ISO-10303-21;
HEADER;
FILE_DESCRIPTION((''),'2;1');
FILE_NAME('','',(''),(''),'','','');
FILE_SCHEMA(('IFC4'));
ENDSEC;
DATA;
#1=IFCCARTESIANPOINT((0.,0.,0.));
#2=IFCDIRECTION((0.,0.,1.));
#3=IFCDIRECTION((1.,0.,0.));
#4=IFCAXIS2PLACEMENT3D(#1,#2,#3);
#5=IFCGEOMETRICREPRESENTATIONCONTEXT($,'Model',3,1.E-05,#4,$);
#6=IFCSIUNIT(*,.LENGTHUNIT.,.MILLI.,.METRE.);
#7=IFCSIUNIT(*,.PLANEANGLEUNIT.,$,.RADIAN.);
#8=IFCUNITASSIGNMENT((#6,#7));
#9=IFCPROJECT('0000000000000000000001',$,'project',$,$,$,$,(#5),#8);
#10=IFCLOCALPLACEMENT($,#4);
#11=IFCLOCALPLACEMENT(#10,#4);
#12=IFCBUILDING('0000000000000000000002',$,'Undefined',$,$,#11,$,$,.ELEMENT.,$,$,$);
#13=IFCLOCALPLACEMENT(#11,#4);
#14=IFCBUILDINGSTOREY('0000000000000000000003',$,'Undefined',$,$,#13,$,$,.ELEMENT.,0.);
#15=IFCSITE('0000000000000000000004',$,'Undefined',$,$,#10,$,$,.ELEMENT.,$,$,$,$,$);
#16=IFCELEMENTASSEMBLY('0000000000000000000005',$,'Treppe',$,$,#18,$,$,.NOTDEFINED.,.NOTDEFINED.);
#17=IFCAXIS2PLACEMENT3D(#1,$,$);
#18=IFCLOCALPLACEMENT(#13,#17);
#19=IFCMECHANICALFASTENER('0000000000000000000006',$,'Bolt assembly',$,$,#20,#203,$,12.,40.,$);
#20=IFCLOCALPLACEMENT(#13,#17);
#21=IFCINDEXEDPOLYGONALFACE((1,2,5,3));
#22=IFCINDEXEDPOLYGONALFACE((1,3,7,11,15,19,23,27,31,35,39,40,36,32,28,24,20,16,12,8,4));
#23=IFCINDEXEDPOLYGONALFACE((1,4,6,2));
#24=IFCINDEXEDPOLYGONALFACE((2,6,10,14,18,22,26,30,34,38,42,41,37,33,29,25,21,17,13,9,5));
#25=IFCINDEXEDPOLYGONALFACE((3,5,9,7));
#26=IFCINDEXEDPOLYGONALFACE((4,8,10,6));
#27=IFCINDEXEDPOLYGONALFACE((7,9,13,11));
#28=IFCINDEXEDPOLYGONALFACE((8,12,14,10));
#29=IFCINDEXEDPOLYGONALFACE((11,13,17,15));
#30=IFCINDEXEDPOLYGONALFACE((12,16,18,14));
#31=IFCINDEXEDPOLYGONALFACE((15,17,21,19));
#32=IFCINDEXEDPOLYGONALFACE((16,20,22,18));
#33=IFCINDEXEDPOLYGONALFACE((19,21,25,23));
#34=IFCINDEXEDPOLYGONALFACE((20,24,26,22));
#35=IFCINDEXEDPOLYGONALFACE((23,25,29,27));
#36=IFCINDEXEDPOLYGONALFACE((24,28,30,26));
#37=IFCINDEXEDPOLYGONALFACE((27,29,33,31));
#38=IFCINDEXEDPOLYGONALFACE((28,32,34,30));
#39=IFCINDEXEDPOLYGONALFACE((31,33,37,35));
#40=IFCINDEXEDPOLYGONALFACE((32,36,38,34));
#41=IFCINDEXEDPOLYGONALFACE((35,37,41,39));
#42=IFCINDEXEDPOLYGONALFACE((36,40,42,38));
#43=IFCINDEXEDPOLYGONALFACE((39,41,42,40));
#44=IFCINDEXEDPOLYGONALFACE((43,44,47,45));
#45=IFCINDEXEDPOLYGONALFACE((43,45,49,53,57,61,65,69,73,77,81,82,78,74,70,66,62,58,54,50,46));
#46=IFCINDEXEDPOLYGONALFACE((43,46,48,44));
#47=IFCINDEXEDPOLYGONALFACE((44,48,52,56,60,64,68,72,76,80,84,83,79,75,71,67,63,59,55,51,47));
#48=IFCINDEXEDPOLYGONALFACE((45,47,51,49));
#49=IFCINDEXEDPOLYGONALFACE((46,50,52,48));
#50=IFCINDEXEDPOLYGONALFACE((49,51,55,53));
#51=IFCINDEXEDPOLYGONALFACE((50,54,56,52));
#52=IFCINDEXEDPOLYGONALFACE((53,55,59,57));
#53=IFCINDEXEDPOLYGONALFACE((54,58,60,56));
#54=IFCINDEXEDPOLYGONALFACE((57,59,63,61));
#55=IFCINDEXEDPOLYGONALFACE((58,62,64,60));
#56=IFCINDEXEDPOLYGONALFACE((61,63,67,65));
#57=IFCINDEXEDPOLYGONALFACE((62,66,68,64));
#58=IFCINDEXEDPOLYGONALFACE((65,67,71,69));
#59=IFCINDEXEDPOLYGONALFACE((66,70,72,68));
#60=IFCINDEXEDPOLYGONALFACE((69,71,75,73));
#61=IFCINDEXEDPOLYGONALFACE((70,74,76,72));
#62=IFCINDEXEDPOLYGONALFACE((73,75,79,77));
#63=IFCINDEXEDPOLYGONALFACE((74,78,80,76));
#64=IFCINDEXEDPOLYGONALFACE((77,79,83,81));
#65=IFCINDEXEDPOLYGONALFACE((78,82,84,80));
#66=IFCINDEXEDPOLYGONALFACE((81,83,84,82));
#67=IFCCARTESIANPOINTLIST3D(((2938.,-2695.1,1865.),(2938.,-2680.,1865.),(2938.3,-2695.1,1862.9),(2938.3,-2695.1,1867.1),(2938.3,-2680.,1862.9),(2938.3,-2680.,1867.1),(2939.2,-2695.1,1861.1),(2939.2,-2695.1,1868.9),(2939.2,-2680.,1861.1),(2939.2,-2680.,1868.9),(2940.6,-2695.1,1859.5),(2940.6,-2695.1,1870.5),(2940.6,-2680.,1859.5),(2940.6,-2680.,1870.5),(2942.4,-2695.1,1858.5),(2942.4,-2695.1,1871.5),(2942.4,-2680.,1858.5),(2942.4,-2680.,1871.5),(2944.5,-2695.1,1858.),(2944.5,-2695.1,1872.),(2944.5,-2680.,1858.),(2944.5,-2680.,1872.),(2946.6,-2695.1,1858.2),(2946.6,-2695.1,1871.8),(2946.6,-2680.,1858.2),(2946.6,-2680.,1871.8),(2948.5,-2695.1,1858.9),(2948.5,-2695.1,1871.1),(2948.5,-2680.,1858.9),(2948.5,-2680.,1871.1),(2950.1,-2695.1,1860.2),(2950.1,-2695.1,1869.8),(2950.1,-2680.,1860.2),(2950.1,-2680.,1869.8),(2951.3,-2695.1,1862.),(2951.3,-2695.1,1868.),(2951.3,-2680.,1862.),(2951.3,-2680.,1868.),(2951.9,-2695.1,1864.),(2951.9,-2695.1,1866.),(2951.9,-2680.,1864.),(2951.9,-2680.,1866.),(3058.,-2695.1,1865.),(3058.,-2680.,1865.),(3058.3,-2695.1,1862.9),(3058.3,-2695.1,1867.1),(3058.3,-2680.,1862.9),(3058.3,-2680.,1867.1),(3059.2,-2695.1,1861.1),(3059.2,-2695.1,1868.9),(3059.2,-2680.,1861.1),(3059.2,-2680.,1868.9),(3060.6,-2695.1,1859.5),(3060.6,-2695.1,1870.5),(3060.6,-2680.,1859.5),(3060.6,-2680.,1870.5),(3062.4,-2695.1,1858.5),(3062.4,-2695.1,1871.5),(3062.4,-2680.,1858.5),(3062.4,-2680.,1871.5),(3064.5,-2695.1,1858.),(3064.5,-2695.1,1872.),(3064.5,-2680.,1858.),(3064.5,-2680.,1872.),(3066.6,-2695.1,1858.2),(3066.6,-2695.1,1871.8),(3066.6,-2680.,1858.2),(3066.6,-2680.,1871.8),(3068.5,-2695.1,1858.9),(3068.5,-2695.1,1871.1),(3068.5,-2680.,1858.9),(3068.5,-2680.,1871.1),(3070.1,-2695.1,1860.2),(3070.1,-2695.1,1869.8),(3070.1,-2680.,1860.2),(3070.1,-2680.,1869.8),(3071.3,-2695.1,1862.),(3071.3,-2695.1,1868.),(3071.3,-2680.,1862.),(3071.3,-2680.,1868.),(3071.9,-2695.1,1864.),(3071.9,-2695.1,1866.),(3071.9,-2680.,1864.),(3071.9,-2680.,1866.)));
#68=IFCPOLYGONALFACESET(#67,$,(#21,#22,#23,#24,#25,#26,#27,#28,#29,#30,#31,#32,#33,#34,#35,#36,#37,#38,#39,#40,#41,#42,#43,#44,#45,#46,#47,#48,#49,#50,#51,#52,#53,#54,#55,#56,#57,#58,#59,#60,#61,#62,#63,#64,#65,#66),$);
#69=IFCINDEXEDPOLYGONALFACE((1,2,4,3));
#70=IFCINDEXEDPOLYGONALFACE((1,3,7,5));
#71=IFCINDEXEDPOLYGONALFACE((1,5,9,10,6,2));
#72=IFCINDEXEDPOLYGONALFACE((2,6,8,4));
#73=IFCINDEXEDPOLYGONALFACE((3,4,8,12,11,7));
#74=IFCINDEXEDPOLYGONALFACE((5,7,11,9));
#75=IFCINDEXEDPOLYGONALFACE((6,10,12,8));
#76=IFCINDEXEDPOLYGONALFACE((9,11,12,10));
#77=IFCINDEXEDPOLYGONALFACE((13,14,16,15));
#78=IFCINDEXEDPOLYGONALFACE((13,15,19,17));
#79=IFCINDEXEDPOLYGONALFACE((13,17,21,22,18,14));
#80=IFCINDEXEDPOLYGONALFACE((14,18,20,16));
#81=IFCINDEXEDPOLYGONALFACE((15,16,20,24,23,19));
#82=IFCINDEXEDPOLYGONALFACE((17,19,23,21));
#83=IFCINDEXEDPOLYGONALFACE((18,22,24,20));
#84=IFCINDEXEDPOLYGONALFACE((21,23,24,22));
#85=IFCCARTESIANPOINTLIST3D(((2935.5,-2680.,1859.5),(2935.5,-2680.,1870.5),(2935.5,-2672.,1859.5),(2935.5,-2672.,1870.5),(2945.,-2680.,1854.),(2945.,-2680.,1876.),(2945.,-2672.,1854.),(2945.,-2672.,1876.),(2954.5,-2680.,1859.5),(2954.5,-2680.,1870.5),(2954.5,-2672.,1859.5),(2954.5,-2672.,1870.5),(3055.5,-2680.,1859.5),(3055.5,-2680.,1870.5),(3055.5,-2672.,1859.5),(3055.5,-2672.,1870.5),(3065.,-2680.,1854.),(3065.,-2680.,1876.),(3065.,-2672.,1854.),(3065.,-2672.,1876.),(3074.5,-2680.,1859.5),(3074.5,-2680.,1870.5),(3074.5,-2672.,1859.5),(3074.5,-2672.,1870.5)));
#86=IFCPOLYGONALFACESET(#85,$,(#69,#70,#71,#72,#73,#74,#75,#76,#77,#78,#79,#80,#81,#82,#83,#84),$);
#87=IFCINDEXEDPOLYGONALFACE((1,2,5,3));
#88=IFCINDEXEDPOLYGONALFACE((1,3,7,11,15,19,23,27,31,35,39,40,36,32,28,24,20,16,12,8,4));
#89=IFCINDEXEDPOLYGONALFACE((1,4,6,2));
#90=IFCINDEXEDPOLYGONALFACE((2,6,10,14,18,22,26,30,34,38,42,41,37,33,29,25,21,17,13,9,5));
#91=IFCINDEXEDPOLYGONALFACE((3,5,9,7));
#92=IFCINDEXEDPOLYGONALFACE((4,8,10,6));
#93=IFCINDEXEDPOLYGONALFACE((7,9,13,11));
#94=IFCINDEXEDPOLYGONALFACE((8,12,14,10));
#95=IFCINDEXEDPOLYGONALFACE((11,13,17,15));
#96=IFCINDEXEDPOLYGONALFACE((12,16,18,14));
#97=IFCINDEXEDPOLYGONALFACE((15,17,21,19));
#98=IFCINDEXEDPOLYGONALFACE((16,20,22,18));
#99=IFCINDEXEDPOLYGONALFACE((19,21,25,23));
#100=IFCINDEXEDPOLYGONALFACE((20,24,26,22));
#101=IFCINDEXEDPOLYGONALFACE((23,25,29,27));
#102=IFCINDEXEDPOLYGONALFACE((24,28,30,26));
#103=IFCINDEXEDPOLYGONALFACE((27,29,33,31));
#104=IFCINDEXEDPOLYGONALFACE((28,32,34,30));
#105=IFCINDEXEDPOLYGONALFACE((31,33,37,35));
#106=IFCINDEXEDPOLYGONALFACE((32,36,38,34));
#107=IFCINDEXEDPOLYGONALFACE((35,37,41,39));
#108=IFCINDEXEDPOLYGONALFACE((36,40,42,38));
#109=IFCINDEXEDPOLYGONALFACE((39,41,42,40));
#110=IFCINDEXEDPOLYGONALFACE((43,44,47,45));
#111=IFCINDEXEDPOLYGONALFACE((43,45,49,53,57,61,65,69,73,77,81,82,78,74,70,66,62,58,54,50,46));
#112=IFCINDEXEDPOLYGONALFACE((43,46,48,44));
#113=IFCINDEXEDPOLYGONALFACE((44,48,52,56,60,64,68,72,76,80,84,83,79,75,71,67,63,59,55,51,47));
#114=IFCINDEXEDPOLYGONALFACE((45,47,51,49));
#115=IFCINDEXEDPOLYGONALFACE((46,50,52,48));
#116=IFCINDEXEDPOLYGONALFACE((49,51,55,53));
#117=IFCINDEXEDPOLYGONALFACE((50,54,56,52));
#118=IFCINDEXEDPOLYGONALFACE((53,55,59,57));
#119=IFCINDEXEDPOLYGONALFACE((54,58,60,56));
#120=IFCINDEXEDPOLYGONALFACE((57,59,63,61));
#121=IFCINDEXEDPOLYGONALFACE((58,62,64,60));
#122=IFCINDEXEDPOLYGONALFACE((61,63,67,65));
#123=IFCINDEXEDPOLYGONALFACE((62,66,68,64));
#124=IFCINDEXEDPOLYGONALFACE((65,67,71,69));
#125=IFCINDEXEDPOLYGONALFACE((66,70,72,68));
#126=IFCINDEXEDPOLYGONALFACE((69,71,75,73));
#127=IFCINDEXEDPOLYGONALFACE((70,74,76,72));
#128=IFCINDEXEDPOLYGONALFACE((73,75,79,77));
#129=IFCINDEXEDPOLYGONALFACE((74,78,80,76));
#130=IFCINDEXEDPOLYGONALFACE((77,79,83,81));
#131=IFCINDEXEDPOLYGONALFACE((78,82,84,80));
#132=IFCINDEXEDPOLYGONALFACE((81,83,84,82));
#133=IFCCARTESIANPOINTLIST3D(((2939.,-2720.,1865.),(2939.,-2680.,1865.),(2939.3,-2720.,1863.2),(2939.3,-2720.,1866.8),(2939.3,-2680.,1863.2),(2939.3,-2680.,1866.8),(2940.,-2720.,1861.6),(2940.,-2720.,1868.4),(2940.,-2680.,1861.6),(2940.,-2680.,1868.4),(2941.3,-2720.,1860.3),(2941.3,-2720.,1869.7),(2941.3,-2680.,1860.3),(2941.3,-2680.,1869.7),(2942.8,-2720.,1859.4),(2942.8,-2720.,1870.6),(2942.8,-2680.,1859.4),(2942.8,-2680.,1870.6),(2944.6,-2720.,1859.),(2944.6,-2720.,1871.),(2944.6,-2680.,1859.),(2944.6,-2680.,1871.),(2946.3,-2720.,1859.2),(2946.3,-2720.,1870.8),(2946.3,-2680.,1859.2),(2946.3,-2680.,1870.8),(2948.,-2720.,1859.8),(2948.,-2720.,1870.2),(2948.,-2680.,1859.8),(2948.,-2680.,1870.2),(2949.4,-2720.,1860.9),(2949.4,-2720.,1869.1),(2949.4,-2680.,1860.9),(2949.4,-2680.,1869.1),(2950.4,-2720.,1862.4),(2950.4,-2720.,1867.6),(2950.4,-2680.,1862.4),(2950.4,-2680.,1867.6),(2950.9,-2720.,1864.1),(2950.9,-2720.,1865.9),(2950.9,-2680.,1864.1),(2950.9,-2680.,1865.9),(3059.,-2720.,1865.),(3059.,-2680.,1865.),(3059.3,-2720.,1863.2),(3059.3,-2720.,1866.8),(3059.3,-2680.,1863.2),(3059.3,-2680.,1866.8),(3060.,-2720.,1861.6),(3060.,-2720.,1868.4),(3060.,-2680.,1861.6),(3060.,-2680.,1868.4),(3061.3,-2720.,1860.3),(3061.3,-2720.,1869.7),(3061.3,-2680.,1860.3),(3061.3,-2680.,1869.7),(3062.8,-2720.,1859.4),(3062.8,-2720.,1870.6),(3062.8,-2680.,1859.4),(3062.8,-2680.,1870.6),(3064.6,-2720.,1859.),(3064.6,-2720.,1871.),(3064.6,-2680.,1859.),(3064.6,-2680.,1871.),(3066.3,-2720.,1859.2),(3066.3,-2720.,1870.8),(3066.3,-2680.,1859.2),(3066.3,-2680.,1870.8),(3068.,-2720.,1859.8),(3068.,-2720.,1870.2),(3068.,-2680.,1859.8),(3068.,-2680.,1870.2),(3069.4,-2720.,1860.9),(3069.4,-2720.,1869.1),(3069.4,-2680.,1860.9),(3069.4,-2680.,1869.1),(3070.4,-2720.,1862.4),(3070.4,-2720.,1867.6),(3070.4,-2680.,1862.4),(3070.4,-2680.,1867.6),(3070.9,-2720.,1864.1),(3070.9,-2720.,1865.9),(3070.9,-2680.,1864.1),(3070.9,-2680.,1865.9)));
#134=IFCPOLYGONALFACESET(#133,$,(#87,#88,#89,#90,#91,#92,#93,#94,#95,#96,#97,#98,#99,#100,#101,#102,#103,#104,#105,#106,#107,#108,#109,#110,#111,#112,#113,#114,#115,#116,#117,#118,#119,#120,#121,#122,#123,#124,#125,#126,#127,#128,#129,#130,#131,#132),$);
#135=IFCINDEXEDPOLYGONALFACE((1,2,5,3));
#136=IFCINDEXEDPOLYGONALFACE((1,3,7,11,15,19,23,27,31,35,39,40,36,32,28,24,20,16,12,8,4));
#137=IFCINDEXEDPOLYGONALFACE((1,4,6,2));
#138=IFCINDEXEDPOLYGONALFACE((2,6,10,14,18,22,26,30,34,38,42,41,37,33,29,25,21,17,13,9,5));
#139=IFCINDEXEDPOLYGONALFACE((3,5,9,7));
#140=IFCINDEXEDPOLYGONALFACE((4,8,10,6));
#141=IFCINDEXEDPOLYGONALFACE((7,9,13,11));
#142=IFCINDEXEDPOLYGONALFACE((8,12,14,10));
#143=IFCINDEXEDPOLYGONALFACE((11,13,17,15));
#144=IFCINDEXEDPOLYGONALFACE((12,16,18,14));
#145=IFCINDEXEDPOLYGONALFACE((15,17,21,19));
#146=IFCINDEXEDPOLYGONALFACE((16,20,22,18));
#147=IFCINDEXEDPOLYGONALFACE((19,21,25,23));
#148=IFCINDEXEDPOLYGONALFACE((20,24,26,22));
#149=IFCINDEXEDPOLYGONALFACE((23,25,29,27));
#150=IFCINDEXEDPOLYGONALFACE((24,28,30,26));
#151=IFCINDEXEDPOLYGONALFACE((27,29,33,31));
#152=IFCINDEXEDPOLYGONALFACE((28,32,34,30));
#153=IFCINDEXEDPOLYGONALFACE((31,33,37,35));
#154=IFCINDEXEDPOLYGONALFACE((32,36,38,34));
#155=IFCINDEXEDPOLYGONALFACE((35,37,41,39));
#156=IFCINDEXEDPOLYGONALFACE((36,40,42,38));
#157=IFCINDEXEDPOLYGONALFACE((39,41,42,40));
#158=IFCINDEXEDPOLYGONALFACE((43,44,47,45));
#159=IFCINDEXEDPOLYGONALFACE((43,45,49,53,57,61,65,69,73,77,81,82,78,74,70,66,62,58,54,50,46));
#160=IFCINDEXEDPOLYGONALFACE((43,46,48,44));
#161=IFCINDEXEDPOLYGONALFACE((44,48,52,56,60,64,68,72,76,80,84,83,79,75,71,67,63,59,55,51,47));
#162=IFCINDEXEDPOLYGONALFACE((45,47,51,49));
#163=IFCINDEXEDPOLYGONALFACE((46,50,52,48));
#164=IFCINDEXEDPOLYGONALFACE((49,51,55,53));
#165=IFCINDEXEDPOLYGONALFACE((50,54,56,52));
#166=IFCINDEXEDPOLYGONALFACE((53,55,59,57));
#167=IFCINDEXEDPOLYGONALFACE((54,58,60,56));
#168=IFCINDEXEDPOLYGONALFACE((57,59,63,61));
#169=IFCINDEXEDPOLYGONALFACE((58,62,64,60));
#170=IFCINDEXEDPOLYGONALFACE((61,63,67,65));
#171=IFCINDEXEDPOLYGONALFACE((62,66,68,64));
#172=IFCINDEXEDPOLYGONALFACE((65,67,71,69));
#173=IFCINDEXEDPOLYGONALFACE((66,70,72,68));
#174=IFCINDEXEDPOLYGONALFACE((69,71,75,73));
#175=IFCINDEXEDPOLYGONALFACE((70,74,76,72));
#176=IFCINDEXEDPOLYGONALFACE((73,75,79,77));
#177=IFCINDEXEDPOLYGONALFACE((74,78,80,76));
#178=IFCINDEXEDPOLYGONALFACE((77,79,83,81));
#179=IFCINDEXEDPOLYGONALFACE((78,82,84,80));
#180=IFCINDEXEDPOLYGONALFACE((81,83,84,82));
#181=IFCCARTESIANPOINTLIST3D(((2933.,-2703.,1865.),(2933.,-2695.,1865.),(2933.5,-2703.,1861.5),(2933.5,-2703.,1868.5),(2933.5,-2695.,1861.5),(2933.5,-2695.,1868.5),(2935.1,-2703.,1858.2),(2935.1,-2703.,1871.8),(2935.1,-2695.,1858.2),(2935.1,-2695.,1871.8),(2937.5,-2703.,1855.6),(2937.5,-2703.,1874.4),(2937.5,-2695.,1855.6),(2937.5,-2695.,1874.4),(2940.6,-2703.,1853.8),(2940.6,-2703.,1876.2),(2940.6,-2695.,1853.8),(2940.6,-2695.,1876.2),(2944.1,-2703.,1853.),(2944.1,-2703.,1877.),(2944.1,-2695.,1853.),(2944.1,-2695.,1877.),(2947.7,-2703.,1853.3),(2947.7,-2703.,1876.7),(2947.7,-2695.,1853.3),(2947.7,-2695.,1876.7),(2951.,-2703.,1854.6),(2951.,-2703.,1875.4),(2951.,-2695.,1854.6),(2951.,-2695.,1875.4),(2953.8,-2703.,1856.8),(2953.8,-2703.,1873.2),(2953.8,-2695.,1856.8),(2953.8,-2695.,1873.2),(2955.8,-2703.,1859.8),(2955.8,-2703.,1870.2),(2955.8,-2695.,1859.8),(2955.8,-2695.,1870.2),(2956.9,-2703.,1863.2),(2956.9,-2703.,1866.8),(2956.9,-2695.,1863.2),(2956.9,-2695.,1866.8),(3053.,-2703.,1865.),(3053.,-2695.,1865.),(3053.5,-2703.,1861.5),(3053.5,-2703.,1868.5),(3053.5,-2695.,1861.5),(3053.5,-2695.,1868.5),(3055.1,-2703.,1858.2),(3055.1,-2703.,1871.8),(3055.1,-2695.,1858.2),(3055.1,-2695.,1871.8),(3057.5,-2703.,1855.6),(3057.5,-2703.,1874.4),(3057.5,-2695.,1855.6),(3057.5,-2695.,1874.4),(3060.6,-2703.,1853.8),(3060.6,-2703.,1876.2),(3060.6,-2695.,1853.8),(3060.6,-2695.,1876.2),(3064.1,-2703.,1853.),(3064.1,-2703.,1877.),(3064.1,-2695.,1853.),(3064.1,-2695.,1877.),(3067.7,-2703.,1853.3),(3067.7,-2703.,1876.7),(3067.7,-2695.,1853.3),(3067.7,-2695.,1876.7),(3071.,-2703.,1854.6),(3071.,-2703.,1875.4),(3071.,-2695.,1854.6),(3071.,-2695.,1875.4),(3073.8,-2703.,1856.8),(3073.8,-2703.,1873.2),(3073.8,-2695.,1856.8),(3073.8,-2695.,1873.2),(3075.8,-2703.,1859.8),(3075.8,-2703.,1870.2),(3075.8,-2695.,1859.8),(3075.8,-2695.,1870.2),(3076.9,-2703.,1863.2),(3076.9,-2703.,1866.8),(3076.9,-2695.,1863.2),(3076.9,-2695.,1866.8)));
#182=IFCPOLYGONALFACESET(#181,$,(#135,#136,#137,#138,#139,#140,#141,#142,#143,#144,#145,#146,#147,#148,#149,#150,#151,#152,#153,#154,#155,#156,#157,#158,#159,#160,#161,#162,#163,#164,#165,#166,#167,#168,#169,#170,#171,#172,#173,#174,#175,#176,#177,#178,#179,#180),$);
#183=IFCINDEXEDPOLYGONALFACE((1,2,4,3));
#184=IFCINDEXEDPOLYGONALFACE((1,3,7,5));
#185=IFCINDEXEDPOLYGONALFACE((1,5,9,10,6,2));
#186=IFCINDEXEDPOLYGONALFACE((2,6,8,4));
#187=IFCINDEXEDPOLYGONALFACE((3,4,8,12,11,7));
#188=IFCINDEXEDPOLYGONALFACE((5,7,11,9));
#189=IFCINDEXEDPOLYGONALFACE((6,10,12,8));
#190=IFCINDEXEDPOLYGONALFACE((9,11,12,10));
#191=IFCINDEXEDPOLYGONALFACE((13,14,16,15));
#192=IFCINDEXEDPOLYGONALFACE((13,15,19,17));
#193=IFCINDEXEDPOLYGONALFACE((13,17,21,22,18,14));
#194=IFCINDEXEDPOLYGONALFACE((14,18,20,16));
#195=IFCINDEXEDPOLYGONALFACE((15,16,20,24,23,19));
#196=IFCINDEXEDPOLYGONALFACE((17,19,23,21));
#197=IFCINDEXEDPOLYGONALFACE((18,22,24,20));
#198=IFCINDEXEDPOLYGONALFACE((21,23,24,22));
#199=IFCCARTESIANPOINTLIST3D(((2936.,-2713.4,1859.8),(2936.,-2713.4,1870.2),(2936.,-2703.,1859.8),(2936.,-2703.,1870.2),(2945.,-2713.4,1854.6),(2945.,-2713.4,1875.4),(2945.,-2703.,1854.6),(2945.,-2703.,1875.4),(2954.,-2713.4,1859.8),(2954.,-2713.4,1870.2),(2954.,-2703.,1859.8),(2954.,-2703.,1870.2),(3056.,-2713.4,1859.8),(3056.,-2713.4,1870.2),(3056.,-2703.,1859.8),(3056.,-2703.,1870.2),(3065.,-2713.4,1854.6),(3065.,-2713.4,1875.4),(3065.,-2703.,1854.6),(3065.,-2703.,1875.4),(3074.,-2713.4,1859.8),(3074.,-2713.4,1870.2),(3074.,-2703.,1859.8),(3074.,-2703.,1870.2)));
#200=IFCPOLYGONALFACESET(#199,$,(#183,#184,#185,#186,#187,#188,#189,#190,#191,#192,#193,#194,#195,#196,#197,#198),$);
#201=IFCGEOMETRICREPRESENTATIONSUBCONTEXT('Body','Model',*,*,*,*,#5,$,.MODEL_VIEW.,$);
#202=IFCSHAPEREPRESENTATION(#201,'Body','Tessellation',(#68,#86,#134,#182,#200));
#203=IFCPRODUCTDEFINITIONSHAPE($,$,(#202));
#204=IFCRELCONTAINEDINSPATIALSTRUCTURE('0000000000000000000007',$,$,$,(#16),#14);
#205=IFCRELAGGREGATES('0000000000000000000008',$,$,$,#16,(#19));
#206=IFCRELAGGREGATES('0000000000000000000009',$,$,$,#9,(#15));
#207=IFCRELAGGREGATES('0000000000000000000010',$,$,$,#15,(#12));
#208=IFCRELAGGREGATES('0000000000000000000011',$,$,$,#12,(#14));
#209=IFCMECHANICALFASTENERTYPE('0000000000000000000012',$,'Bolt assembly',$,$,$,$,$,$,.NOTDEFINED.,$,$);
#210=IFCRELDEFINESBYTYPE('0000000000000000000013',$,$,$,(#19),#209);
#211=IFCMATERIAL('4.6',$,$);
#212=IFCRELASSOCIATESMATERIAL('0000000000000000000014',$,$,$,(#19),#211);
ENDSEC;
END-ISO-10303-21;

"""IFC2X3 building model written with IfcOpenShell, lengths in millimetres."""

from ifc_helpers import new_model, si_unit, frame, origin_with_axes, origin_2d_with_axis, place, context, subcontext, project, spatial, polyline, circle, outline, extrude, source, transform, mapped, material, type_object, element, aggregate, save


model = new_model("IFC2X3")

# Units and contexts
model_context = context("Model", 3, precision=1e-05, world=origin_with_axes())
body_context = subcontext(model_context, "Body", "Model", "MODEL_VIEW")
ifc_project = project(units=[si_unit("LENGTHUNIT", "METRE", prefix="MILLI"), si_unit("PLANEANGLEUNIT", "RADIAN")], contexts=[model_context])

# Site, building, storey
site_placement = place(None, origin_with_axes())
site = spatial("IfcSite", under=ifc_project, at=site_placement, Name="Undefined", CompositionType="ELEMENT")
building_placement = place(site_placement, origin_with_axes())
building = spatial("IfcBuilding", under=site, at=building_placement, Name="Undefined", CompositionType="ELEMENT")
storey_placement = place(building_placement, origin_with_axes())
storey = spatial("IfcBuildingStorey", under=building, at=storey_placement, Name="Undefined", CompositionType="ELEMENT", Elevation=0.0)

# Element assembly, mechanical fastener
ifc_material_1 = material(Name="4.6")
mechanical_fastener_type = type_object("IfcMechanicalFastenerType", Name="Bolt assembly")
assembly_1_placement = place(storey_placement, origin_with_axes())
assembly_1 = element("IfcElementAssembly", 1, at=assembly_1_placement, inside=storey, Name="Treppe", AssemblyPlace="NOTDEFINED", PredefinedType="NOTDEFINED")
shared_shape_1 = source(origin_with_axes(), body_context, "Body", "SweptSolid", [
    extrude(circle(Radius=7.0, at=origin_2d_with_axis()), frame((0.0, -15.0, 0.0), z_axis=(0.0, 1.0, 0.0), x_axis=(1.0, 0.0, 0.0)), (0.0, 0.0, 1.0), 15.1),
    extrude(outline(polyline([(9.5, -5.5), (9.5, 5.5), (0.0, 11.0), (-9.5, 5.5), (-9.5, -5.5), (0.0, -11.0), (9.5, -5.5)])), frame((0.0, -23.0, 0.0), z_axis=(0.0, 1.0, 0.0), x_axis=(1.0, 0.0, 0.0)), (0.0, 0.0, 1.0), 8.0),
    extrude(circle(Radius=6.0, at=origin_2d_with_axis()), frame((0.0, -15.0, 0.0), z_axis=(0.0, 1.0, 0.0), x_axis=(1.0, 0.0, 0.0)), (0.0, 0.0, 1.0), 40.0),
    extrude(circle(Radius=12.0, at=origin_2d_with_axis()), frame((0.0, 0.0, 0.0), z_axis=(0.0, 1.0, 0.0), x_axis=(1.0, 0.0, 0.0)), (0.0, 0.0, 1.0), 8.0),
    extrude(outline(polyline([(9.0, -5.2), (9.0, 5.2), (0.0, 10.4), (-9.0, 5.2), (-9.0, -5.2), (0.0, -10.4), (9.0, -5.2)])), frame((0.0, 8.0, 0.0), z_axis=(0.0, 1.0, 0.0), x_axis=(1.0, 0.0, 0.0)), (0.0, 0.0, 1.0), 10.4),
])
mechanical_fastener_1_placement = place(assembly_1_placement, frame((3065.0, -2695.0, 1865.0), z_axis=(0.0, 0.0, 1.0), x_axis=(-1.0, 0.0, 0.0)))
mechanical_fastener_1 = element("IfcMechanicalFastener", 2, at=mechanical_fastener_1_placement, type_object=mechanical_fastener_type, material=ifc_material_1, Name="Bolt assembly", NominalDiameter=12.0, NominalLength=40.0, context=body_context, shape_type="MappedRepresentation", body=[
    mapped(shared_shape_1, transform((0.0, 0.0, 0.0))),
    mapped(shared_shape_1, transform((120.0, 0.0, 0.0))),
])
aggregate(assembly_1, [mechanical_fastener_1])

save(model, "model.ifc")
